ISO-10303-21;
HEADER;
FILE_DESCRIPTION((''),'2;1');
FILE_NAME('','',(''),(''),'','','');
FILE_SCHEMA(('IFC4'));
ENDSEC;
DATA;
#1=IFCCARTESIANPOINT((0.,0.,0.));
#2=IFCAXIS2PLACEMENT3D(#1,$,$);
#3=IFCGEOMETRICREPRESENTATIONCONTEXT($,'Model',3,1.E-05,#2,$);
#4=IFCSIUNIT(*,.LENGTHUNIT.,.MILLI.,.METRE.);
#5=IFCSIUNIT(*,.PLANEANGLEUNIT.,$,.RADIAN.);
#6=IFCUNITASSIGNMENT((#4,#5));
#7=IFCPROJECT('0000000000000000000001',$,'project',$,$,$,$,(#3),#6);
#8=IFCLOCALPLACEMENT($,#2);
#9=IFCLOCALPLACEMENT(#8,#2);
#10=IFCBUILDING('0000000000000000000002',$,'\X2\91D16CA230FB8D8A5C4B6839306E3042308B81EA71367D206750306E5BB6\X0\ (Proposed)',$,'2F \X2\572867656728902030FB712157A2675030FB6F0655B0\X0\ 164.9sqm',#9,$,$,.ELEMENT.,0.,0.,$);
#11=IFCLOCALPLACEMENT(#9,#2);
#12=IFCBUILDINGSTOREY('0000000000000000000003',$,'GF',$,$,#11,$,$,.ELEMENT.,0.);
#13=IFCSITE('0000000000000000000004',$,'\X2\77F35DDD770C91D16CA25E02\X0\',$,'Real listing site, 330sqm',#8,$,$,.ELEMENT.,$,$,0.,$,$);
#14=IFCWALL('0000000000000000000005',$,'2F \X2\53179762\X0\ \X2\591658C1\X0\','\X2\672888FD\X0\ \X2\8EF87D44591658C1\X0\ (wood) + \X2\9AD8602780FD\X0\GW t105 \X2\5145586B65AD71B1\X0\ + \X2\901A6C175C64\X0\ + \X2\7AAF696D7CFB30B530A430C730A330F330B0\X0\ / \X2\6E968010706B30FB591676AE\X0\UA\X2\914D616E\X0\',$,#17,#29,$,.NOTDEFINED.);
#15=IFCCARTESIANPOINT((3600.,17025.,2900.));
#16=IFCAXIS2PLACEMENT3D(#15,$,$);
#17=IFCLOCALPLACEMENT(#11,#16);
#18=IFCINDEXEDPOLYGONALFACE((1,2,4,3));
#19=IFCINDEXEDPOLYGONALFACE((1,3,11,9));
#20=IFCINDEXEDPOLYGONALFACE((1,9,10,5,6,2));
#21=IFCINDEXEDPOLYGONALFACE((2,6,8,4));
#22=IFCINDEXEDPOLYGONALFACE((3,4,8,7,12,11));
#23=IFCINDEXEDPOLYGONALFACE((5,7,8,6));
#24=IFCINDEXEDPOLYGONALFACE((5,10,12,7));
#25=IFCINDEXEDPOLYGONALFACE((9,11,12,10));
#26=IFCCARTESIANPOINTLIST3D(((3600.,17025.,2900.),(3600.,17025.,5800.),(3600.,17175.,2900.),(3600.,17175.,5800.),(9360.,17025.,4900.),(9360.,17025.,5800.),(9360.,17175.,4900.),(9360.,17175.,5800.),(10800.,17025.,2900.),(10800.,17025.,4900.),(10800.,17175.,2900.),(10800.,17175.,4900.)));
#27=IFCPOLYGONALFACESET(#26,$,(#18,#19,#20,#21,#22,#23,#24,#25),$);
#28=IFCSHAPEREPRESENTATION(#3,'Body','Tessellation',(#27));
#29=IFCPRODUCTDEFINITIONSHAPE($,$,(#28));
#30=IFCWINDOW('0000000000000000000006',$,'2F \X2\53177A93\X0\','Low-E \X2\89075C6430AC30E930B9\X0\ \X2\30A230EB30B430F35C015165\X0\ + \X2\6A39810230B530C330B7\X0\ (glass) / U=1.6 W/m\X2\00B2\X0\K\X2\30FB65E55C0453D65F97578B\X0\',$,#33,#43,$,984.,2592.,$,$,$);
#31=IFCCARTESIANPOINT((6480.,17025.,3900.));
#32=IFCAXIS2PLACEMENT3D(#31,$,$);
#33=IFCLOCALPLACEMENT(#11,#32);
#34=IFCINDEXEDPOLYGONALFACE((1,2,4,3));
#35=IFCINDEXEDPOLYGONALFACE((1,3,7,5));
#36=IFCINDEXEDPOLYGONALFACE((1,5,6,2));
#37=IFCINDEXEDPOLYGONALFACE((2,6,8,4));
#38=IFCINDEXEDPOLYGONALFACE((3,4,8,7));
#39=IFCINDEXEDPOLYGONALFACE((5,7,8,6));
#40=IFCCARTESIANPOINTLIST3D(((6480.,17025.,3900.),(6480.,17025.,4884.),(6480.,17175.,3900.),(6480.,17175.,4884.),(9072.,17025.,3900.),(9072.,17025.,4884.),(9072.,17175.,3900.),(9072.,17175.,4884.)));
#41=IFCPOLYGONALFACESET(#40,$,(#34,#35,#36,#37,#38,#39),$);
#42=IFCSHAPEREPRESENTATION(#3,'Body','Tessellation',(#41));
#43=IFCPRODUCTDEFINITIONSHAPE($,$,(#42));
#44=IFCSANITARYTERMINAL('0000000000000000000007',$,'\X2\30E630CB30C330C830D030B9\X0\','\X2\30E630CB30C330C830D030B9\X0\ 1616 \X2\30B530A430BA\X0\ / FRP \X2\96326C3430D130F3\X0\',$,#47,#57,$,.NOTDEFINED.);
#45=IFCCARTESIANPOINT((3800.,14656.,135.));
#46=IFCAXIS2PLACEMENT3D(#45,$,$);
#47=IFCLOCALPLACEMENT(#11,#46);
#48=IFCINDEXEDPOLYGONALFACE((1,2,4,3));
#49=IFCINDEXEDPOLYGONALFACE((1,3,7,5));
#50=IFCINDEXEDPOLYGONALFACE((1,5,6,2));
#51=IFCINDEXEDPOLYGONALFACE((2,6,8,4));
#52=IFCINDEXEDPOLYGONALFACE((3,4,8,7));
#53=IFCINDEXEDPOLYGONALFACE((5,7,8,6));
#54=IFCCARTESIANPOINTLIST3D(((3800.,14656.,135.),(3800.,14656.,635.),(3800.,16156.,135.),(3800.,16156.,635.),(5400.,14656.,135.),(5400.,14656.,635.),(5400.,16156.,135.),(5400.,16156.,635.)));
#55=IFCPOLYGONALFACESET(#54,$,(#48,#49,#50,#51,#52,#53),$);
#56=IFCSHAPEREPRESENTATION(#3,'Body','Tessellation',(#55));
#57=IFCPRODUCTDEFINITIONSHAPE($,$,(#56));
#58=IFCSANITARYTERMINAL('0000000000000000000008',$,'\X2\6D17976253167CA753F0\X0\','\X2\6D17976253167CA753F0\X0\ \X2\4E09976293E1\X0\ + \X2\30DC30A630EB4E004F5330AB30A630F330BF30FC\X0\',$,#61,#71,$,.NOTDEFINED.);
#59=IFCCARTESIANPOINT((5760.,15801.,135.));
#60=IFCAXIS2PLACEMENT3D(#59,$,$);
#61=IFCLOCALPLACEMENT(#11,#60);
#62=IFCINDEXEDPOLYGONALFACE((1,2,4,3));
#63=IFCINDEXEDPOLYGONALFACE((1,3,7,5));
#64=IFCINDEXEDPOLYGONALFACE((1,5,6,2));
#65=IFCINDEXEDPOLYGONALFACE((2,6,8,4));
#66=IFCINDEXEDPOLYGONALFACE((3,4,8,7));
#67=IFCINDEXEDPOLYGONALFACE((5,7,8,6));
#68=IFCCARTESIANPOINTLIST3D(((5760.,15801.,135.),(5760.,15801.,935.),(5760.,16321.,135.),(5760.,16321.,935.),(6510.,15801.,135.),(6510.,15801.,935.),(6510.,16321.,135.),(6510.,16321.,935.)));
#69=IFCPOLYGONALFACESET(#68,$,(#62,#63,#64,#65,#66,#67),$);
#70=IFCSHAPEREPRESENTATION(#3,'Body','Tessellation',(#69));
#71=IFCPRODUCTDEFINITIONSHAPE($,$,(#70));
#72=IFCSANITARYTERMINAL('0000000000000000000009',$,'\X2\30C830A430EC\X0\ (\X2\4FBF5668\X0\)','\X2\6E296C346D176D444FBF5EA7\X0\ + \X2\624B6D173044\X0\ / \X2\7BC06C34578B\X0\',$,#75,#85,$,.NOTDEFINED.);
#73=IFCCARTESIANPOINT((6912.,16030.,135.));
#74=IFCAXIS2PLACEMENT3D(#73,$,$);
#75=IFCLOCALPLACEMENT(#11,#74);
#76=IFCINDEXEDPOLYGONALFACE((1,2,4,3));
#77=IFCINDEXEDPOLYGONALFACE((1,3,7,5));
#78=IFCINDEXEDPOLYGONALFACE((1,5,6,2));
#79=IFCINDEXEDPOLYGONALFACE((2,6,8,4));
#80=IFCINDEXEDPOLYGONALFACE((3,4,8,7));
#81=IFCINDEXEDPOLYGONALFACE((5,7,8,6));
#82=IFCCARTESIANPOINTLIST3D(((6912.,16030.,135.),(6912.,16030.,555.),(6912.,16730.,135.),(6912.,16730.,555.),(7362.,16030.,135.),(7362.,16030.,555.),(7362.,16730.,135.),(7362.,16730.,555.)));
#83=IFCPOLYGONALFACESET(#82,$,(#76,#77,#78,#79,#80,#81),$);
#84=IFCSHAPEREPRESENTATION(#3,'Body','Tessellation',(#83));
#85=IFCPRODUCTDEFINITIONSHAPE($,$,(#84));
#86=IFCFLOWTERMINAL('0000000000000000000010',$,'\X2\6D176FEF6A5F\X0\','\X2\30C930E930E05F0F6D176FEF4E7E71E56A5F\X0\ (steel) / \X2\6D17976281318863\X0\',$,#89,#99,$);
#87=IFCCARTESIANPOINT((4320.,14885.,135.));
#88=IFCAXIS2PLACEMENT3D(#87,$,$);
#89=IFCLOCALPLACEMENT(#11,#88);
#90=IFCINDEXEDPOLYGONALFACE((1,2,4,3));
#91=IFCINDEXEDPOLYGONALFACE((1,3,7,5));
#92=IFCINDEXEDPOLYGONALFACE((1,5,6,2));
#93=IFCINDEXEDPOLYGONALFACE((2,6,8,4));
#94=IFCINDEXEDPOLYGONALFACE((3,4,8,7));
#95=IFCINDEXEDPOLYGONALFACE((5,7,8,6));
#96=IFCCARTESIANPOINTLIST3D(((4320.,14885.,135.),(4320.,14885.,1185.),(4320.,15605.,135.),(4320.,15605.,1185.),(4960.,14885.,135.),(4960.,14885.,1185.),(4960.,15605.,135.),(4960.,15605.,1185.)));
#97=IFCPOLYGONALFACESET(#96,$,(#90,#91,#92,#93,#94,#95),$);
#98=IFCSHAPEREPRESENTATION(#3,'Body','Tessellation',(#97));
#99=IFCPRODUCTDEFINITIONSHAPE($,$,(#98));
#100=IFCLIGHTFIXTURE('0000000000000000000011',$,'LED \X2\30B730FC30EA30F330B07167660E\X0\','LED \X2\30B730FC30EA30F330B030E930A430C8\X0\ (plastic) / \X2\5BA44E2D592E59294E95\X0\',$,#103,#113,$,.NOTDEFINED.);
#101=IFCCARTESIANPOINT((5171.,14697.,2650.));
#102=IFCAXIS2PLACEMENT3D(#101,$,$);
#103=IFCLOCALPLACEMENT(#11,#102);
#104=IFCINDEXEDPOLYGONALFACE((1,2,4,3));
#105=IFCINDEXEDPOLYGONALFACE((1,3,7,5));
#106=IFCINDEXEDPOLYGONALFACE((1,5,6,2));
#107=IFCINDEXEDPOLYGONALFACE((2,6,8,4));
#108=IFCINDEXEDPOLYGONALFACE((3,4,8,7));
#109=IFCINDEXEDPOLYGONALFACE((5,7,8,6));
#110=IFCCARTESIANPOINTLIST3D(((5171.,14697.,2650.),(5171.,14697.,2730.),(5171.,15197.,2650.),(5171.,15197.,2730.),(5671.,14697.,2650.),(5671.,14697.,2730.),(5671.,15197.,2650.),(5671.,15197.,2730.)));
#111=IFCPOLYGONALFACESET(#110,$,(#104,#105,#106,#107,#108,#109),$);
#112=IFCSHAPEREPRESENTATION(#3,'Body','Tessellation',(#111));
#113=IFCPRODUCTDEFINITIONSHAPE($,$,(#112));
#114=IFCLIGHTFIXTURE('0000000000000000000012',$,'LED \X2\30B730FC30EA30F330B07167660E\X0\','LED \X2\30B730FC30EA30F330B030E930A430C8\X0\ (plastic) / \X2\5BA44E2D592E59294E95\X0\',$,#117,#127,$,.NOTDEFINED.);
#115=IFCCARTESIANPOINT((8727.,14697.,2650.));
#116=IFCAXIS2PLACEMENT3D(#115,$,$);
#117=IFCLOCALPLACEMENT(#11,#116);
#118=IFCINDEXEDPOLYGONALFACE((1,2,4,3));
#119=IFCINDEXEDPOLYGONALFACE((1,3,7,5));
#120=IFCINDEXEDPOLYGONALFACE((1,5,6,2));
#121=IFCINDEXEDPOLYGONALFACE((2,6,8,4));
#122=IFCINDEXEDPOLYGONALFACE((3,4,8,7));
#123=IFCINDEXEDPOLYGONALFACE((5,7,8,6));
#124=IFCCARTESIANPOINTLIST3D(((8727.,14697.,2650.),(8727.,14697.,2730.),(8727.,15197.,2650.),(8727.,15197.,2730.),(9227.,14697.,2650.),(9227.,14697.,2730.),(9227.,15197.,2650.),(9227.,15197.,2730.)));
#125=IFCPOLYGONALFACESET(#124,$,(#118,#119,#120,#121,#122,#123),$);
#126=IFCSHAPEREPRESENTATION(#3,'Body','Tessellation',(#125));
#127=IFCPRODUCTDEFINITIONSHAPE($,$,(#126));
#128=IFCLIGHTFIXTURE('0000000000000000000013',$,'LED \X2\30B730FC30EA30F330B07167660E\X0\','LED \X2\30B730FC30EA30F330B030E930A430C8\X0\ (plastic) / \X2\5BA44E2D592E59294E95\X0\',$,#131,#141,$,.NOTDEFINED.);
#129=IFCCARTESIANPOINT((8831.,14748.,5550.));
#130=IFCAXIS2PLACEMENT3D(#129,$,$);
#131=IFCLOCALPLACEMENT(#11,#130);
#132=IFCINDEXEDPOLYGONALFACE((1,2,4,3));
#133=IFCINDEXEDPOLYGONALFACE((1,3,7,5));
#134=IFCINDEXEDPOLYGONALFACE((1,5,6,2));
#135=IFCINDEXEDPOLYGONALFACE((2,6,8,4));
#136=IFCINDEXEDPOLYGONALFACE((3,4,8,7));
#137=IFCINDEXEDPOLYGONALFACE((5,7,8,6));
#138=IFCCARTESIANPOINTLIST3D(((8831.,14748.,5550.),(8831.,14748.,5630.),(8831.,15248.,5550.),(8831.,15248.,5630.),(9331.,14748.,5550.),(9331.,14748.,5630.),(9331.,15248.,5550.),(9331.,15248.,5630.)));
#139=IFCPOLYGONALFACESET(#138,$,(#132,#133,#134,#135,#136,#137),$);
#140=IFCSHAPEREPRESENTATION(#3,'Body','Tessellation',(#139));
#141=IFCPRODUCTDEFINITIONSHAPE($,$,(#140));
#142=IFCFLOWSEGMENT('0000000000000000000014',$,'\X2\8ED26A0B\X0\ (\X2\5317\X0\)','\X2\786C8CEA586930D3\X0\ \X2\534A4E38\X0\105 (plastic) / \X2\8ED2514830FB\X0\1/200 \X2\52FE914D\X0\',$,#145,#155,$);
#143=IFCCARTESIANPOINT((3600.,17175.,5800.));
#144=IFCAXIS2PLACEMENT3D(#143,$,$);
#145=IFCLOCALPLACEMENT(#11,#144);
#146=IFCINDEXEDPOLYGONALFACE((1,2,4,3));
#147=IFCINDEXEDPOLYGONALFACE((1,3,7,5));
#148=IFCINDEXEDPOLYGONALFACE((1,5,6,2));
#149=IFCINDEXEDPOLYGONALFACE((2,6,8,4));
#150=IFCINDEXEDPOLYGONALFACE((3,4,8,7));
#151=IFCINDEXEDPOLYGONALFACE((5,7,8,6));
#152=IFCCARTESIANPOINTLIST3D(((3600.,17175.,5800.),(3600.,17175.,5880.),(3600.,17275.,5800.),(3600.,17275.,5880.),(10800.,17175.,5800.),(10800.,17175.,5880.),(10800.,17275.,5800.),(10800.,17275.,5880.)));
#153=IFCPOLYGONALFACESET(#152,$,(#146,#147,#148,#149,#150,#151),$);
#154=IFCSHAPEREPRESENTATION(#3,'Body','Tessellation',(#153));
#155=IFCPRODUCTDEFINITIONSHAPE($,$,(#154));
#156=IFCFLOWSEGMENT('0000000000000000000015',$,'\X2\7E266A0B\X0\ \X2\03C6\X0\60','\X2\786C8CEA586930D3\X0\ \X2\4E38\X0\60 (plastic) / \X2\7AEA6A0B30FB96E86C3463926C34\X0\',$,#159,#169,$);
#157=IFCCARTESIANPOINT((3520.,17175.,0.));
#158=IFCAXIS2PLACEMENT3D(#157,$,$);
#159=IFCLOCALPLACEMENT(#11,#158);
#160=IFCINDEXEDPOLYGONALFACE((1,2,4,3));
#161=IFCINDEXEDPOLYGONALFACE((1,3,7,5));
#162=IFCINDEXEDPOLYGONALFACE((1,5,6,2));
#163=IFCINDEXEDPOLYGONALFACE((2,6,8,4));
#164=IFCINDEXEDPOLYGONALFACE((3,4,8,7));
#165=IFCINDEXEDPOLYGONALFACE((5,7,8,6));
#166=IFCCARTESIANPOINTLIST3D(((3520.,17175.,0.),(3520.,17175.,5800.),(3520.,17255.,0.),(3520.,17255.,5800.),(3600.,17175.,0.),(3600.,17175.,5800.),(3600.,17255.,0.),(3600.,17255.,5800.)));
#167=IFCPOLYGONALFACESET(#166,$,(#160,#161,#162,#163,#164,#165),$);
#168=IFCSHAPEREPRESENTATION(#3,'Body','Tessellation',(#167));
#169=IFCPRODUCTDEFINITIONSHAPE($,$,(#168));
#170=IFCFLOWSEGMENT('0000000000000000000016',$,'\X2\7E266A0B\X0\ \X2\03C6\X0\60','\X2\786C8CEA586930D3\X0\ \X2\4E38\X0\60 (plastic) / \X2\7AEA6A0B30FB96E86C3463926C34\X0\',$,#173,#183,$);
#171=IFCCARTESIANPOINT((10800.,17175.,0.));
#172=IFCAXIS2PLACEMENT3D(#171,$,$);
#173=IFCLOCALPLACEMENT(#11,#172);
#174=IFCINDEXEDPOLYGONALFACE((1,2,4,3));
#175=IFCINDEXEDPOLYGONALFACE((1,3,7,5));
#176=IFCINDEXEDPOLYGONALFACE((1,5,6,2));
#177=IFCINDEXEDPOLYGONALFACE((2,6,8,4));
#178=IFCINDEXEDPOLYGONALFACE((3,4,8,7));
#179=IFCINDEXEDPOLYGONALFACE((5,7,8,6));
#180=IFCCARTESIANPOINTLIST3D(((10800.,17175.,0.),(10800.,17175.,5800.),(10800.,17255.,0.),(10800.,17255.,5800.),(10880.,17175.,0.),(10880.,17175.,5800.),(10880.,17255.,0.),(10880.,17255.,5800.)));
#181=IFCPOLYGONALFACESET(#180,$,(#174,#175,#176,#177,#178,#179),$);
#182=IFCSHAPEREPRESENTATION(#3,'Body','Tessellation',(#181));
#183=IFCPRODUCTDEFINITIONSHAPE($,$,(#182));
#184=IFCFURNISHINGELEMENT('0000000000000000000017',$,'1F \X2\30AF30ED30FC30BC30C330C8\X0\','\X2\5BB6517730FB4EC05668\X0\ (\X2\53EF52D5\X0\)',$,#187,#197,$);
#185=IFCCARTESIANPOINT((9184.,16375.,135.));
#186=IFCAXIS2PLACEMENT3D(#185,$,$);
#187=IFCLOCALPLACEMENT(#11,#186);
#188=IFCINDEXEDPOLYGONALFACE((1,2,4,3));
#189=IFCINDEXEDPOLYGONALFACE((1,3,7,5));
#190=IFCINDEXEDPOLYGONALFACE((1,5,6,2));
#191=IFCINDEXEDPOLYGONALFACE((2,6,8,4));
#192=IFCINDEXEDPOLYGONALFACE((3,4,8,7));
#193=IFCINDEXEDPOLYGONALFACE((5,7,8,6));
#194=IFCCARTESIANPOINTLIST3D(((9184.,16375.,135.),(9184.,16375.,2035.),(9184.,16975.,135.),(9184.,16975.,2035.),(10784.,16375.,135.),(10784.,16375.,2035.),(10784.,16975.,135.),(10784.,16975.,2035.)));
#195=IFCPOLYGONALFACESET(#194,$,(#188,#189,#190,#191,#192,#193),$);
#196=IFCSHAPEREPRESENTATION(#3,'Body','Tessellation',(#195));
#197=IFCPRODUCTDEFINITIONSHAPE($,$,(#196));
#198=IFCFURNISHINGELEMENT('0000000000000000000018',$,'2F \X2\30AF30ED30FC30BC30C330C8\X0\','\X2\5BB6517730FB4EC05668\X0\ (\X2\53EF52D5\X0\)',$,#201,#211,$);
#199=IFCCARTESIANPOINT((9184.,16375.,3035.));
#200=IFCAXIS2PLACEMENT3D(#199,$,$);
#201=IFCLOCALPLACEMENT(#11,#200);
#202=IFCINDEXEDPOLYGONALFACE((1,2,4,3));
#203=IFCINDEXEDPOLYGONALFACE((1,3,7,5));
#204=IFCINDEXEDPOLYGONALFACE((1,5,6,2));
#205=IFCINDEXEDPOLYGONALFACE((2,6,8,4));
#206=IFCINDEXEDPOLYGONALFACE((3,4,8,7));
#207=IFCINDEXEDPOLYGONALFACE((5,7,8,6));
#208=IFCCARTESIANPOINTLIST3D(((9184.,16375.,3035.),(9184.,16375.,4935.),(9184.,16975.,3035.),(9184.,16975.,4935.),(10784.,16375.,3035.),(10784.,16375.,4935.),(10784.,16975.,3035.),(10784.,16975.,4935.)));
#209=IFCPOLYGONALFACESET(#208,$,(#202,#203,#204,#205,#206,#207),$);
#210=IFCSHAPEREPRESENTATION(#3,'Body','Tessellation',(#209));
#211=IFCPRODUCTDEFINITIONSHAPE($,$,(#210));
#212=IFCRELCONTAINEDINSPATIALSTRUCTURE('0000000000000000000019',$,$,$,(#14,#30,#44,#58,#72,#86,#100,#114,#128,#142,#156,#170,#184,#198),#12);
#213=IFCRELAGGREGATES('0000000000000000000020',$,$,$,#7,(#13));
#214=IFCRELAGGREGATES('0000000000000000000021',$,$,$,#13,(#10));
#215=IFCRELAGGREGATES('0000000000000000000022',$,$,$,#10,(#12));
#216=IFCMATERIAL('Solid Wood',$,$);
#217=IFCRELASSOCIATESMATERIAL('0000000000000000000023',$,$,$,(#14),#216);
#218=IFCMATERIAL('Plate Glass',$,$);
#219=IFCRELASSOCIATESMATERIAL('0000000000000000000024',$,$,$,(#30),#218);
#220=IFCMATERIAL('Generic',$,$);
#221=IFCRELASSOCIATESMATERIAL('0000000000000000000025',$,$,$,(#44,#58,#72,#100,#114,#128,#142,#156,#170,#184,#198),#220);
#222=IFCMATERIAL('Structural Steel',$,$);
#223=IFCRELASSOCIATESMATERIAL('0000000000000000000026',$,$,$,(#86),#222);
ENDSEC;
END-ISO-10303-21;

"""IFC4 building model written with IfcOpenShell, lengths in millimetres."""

from ifc_helpers import new_model, si_unit, frame, frame_2d, origin, place, context, project, spatial, rectangle, extrude, material, element, fill, save


model = new_model("IFC4")

# Units and contexts
model_context = context("Model", 3, precision=1e-05, world=origin())
ifc_project = project(units=[si_unit("LENGTHUNIT", "METRE", prefix="MILLI"), si_unit("PLANEANGLEUNIT", "RADIAN")], contexts=[model_context])

# Site, building, storey
site_placement = place(None, origin())
site = spatial("IfcSite", under=ifc_project, at=site_placement, Name="石川県金沢市", ObjectType="Real listing site, 330sqm", CompositionType="ELEMENT", RefElevation=0.0)
building_placement = place(site_placement, origin())
building = spatial("IfcBuilding", under=site, at=building_placement, Name="金沢・越屋根のある自然素材の家 (Proposed)", ObjectType="2F 在来木造・無垢材・漆喰 164.9sqm", CompositionType="ELEMENT", ElevationOfRefHeight=0.0, ElevationOfTerrain=0.0)
storey_placement = place(building_placement, origin())
storey = spatial("IfcBuildingStorey", under=building, at=storey_placement, Name="GF", CompositionType="ELEMENT", Elevation=0.0)

# Shared definitions
ifc_material_1 = material(Name="Solid Wood")

# Shared definitions
ifc_material_2 = material(Name="Plate Glass")

# Wall, opening, window
wall_1_placement = place(storey_placement, frame((3600.0, 17025.0, 2900.0)))
wall_1 = element("IfcWall", 1, at=wall_1_placement, inside=storey, material=ifc_material_1, Name="2F 北面 外壁", Description="木製 軸組外壁 (wood) + 高性能GW t105 充填断熱 + 通気層 + 窯業系サイディング / 準耐火・外皮UA配慮", PredefinedType="NOTDEFINED", context=model_context, shape_type="SweptSolid", body=[
    extrude(rectangle(XDim=7200.0, YDim=150.0, at=frame_2d((3600.0, 75.0))), frame((3600.0, 17025.0, 2900.0)), (0.0, 0.0, 1.0), 2900.0),
])
opening_1_placement = place(storey_placement, frame((6480.0, 17025.0, 3900.0)))
opening_1 = element("IfcOpeningElement", 2, at=opening_1_placement, cuts=wall_1, PredefinedType="NOTDEFINED", context=model_context, shape_type="SweptSolid", body=[
    extrude(rectangle(XDim=2592.0, YDim=150.0, at=frame_2d((1296.0, 75.0))), frame((6480.0, 17025.0, 3900.0)), (0.0, 0.0, 1.0), 984.0),
])
window_1_placement = place(storey_placement, frame((6480.0, 17025.0, 3900.0)))
window_1 = element("IfcWindow", 3, at=window_1_placement, inside=storey, material=ifc_material_2, Name="2F 北窓", Description="Low-E 複層ガラス アルゴン封入 + 樹脂サッシ (glass) / U=1.6 W/m²K・日射取得型", OverallHeight=984.0, OverallWidth=2592.0, context=model_context, shape_type="SweptSolid", body=[
    extrude(rectangle(XDim=2592.0, YDim=150.0, at=frame_2d((1296.0, 75.0))), frame((6480.0, 17025.0, 3900.0)), (0.0, 0.0, 1.0), 984.0),
])
fill(opening_1, window_1)

# Sanitary terminals
ifc_material_3 = material(Name="Generic")
sanitary_terminal_1_placement = place(storey_placement, frame((3800.0, 14656.0, 135.0)))
element("IfcSanitaryTerminal", 4, at=sanitary_terminal_1_placement, inside=storey, material=ifc_material_3, Name="ユニットバス", Description="ユニットバス 1616 サイズ / FRP 防水パン", PredefinedType="NOTDEFINED", context=model_context, shape_type="SweptSolid", body=[
    extrude(rectangle(XDim=1600.0, YDim=1500.0, at=frame_2d((800.0, 750.0))), frame((3800.0, 14656.0, 135.0)), (0.0, 0.0, 1.0), 500.0),
])
sanitary_terminal_2_placement = place(storey_placement, frame((5760.0, 15801.0, 135.0)))
element("IfcSanitaryTerminal", 5, at=sanitary_terminal_2_placement, inside=storey, material=ifc_material_3, Name="洗面化粧台", Description="洗面化粧台 三面鏡 + ボウル一体カウンター", PredefinedType="NOTDEFINED", context=model_context, shape_type="SweptSolid", body=[
    extrude(rectangle(XDim=750.0, YDim=520.0, at=frame_2d((375.0, 260.0))), frame((5760.0, 15801.0, 135.0)), (0.0, 0.0, 1.0), 800.0),
])
sanitary_terminal_3_placement = place(storey_placement, frame((6912.0, 16030.0, 135.0)))
element("IfcSanitaryTerminal", 6, at=sanitary_terminal_3_placement, inside=storey, material=ifc_material_3, Name="トイレ (便器)", Description="温水洗浄便座 + 手洗い / 節水型", PredefinedType="NOTDEFINED", context=model_context, shape_type="SweptSolid", body=[
    extrude(rectangle(XDim=450.0, YDim=700.0, at=frame_2d((225.0, 350.0))), frame((6912.0, 16030.0, 135.0)), (0.0, 0.0, 1.0), 420.0),
])

# Flow terminal
ifc_material_4 = material(Name="Structural Steel")
flow_terminal_placement = place(storey_placement, frame((4320.0, 14885.0, 135.0)))
element("IfcFlowTerminal", 7, at=flow_terminal_placement, inside=storey, material=ifc_material_4, Name="洗濯機", Description="ドラム式洗濯乾燥機 (steel) / 洗面脱衣", context=model_context, shape_type="SweptSolid", body=[
    extrude(rectangle(XDim=640.0, YDim=720.0, at=frame_2d((320.0, 360.0))), frame((4320.0, 14885.0, 135.0)), (0.0, 0.0, 1.0), 1050.0),
])

# Light fixtures
light_fixture_1_placement = place(storey_placement, frame((5171.0, 14697.0, 2650.0)))
element("IfcLightFixture", 8, at=light_fixture_1_placement, inside=storey, material=ifc_material_3, Name="LED シーリング照明", Description="LED シーリングライト (plastic) / 室中央天井", PredefinedType="NOTDEFINED", context=model_context, shape_type="SweptSolid", body=[
    extrude(rectangle(XDim=500.0, YDim=500.0, at=frame_2d((250.0, 250.0))), frame((5171.0, 14697.0, 2650.0)), (0.0, 0.0, 1.0), 80.0),
])
light_fixture_2_placement = place(storey_placement, frame((8727.0, 14697.0, 2650.0)))
element("IfcLightFixture", 9, at=light_fixture_2_placement, inside=storey, material=ifc_material_3, Name="LED シーリング照明", Description="LED シーリングライト (plastic) / 室中央天井", PredefinedType="NOTDEFINED", context=model_context, shape_type="SweptSolid", body=[
    extrude(rectangle(XDim=500.0, YDim=500.0, at=frame_2d((250.0, 250.0))), frame((8727.0, 14697.0, 2650.0)), (0.0, 0.0, 1.0), 80.0),
])
light_fixture_3_placement = place(storey_placement, frame((8831.0, 14748.0, 5550.0)))
element("IfcLightFixture", 10, at=light_fixture_3_placement, inside=storey, material=ifc_material_3, Name="LED シーリング照明", Description="LED シーリングライト (plastic) / 室中央天井", PredefinedType="NOTDEFINED", context=model_context, shape_type="SweptSolid", body=[
    extrude(rectangle(XDim=500.0, YDim=500.0, at=frame_2d((250.0, 250.0))), frame((8831.0, 14748.0, 5550.0)), (0.0, 0.0, 1.0), 80.0),
])

# Flow segments
flow_segment_1_placement = place(storey_placement, frame((3600.0, 17175.0, 5800.0)))
element("IfcFlowSegment", 11, at=flow_segment_1_placement, inside=storey, material=ifc_material_3, Name="軒樋 (北)", Description="硬質塩ビ 半丸105 (plastic) / 軒先・1/200 勾配", context=model_context, shape_type="SweptSolid", body=[
    extrude(rectangle(XDim=7200.0, YDim=100.0, at=frame_2d((3600.0, 50.0))), frame((3600.0, 17175.0, 5800.0)), (0.0, 0.0, 1.0), 80.0),
])
flow_segment_2_placement = place(storey_placement, frame((3520.0, 17175.0, 0.0)))
element("IfcFlowSegment", 12, at=flow_segment_2_placement, inside=storey, material=ifc_material_3, Name="縦樋 φ60", Description="硬質塩ビ 丸60 (plastic) / 竪樋・雨水排水", context=model_context, shape_type="SweptSolid", body=[
    extrude(rectangle(XDim=80.0, YDim=80.0, at=frame_2d((40.0, 40.0))), frame((3520.0, 17175.0, 0.0)), (0.0, 0.0, 1.0), 5800.0),
])
flow_segment_3_placement = place(storey_placement, frame((10800.0, 17175.0, 0.0)))
element("IfcFlowSegment", 13, at=flow_segment_3_placement, inside=storey, material=ifc_material_3, Name="縦樋 φ60", Description="硬質塩ビ 丸60 (plastic) / 竪樋・雨水排水", context=model_context, shape_type="SweptSolid", body=[
    extrude(rectangle(XDim=80.0, YDim=80.0, at=frame_2d((40.0, 40.0))), frame((10800.0, 17175.0, 0.0)), (0.0, 0.0, 1.0), 5800.0),
])

# Furnishing elements
furnishing_1_placement = place(storey_placement, frame((9184.0, 16375.0, 135.0)))
element("IfcFurnishingElement", 14, at=furnishing_1_placement, inside=storey, material=ifc_material_3, Name="1F クローゼット", Description="家具・什器 (可動)", context=model_context, shape_type="SweptSolid", body=[
    extrude(rectangle(XDim=1600.0, YDim=600.0, at=frame_2d((800.0, 300.0))), frame((9184.0, 16375.0, 135.0)), (0.0, 0.0, 1.0), 1900.0),
])
furnishing_2_placement = place(storey_placement, frame((9184.0, 16375.0, 3035.0)))
element("IfcFurnishingElement", 15, at=furnishing_2_placement, inside=storey, material=ifc_material_3, Name="2F クローゼット", Description="家具・什器 (可動)", context=model_context, shape_type="SweptSolid", body=[
    extrude(rectangle(XDim=1600.0, YDim=600.0, at=frame_2d((800.0, 300.0))), frame((9184.0, 16375.0, 3035.0)), (0.0, 0.0, 1.0), 1900.0),
])

save(model, "model.ifc")
